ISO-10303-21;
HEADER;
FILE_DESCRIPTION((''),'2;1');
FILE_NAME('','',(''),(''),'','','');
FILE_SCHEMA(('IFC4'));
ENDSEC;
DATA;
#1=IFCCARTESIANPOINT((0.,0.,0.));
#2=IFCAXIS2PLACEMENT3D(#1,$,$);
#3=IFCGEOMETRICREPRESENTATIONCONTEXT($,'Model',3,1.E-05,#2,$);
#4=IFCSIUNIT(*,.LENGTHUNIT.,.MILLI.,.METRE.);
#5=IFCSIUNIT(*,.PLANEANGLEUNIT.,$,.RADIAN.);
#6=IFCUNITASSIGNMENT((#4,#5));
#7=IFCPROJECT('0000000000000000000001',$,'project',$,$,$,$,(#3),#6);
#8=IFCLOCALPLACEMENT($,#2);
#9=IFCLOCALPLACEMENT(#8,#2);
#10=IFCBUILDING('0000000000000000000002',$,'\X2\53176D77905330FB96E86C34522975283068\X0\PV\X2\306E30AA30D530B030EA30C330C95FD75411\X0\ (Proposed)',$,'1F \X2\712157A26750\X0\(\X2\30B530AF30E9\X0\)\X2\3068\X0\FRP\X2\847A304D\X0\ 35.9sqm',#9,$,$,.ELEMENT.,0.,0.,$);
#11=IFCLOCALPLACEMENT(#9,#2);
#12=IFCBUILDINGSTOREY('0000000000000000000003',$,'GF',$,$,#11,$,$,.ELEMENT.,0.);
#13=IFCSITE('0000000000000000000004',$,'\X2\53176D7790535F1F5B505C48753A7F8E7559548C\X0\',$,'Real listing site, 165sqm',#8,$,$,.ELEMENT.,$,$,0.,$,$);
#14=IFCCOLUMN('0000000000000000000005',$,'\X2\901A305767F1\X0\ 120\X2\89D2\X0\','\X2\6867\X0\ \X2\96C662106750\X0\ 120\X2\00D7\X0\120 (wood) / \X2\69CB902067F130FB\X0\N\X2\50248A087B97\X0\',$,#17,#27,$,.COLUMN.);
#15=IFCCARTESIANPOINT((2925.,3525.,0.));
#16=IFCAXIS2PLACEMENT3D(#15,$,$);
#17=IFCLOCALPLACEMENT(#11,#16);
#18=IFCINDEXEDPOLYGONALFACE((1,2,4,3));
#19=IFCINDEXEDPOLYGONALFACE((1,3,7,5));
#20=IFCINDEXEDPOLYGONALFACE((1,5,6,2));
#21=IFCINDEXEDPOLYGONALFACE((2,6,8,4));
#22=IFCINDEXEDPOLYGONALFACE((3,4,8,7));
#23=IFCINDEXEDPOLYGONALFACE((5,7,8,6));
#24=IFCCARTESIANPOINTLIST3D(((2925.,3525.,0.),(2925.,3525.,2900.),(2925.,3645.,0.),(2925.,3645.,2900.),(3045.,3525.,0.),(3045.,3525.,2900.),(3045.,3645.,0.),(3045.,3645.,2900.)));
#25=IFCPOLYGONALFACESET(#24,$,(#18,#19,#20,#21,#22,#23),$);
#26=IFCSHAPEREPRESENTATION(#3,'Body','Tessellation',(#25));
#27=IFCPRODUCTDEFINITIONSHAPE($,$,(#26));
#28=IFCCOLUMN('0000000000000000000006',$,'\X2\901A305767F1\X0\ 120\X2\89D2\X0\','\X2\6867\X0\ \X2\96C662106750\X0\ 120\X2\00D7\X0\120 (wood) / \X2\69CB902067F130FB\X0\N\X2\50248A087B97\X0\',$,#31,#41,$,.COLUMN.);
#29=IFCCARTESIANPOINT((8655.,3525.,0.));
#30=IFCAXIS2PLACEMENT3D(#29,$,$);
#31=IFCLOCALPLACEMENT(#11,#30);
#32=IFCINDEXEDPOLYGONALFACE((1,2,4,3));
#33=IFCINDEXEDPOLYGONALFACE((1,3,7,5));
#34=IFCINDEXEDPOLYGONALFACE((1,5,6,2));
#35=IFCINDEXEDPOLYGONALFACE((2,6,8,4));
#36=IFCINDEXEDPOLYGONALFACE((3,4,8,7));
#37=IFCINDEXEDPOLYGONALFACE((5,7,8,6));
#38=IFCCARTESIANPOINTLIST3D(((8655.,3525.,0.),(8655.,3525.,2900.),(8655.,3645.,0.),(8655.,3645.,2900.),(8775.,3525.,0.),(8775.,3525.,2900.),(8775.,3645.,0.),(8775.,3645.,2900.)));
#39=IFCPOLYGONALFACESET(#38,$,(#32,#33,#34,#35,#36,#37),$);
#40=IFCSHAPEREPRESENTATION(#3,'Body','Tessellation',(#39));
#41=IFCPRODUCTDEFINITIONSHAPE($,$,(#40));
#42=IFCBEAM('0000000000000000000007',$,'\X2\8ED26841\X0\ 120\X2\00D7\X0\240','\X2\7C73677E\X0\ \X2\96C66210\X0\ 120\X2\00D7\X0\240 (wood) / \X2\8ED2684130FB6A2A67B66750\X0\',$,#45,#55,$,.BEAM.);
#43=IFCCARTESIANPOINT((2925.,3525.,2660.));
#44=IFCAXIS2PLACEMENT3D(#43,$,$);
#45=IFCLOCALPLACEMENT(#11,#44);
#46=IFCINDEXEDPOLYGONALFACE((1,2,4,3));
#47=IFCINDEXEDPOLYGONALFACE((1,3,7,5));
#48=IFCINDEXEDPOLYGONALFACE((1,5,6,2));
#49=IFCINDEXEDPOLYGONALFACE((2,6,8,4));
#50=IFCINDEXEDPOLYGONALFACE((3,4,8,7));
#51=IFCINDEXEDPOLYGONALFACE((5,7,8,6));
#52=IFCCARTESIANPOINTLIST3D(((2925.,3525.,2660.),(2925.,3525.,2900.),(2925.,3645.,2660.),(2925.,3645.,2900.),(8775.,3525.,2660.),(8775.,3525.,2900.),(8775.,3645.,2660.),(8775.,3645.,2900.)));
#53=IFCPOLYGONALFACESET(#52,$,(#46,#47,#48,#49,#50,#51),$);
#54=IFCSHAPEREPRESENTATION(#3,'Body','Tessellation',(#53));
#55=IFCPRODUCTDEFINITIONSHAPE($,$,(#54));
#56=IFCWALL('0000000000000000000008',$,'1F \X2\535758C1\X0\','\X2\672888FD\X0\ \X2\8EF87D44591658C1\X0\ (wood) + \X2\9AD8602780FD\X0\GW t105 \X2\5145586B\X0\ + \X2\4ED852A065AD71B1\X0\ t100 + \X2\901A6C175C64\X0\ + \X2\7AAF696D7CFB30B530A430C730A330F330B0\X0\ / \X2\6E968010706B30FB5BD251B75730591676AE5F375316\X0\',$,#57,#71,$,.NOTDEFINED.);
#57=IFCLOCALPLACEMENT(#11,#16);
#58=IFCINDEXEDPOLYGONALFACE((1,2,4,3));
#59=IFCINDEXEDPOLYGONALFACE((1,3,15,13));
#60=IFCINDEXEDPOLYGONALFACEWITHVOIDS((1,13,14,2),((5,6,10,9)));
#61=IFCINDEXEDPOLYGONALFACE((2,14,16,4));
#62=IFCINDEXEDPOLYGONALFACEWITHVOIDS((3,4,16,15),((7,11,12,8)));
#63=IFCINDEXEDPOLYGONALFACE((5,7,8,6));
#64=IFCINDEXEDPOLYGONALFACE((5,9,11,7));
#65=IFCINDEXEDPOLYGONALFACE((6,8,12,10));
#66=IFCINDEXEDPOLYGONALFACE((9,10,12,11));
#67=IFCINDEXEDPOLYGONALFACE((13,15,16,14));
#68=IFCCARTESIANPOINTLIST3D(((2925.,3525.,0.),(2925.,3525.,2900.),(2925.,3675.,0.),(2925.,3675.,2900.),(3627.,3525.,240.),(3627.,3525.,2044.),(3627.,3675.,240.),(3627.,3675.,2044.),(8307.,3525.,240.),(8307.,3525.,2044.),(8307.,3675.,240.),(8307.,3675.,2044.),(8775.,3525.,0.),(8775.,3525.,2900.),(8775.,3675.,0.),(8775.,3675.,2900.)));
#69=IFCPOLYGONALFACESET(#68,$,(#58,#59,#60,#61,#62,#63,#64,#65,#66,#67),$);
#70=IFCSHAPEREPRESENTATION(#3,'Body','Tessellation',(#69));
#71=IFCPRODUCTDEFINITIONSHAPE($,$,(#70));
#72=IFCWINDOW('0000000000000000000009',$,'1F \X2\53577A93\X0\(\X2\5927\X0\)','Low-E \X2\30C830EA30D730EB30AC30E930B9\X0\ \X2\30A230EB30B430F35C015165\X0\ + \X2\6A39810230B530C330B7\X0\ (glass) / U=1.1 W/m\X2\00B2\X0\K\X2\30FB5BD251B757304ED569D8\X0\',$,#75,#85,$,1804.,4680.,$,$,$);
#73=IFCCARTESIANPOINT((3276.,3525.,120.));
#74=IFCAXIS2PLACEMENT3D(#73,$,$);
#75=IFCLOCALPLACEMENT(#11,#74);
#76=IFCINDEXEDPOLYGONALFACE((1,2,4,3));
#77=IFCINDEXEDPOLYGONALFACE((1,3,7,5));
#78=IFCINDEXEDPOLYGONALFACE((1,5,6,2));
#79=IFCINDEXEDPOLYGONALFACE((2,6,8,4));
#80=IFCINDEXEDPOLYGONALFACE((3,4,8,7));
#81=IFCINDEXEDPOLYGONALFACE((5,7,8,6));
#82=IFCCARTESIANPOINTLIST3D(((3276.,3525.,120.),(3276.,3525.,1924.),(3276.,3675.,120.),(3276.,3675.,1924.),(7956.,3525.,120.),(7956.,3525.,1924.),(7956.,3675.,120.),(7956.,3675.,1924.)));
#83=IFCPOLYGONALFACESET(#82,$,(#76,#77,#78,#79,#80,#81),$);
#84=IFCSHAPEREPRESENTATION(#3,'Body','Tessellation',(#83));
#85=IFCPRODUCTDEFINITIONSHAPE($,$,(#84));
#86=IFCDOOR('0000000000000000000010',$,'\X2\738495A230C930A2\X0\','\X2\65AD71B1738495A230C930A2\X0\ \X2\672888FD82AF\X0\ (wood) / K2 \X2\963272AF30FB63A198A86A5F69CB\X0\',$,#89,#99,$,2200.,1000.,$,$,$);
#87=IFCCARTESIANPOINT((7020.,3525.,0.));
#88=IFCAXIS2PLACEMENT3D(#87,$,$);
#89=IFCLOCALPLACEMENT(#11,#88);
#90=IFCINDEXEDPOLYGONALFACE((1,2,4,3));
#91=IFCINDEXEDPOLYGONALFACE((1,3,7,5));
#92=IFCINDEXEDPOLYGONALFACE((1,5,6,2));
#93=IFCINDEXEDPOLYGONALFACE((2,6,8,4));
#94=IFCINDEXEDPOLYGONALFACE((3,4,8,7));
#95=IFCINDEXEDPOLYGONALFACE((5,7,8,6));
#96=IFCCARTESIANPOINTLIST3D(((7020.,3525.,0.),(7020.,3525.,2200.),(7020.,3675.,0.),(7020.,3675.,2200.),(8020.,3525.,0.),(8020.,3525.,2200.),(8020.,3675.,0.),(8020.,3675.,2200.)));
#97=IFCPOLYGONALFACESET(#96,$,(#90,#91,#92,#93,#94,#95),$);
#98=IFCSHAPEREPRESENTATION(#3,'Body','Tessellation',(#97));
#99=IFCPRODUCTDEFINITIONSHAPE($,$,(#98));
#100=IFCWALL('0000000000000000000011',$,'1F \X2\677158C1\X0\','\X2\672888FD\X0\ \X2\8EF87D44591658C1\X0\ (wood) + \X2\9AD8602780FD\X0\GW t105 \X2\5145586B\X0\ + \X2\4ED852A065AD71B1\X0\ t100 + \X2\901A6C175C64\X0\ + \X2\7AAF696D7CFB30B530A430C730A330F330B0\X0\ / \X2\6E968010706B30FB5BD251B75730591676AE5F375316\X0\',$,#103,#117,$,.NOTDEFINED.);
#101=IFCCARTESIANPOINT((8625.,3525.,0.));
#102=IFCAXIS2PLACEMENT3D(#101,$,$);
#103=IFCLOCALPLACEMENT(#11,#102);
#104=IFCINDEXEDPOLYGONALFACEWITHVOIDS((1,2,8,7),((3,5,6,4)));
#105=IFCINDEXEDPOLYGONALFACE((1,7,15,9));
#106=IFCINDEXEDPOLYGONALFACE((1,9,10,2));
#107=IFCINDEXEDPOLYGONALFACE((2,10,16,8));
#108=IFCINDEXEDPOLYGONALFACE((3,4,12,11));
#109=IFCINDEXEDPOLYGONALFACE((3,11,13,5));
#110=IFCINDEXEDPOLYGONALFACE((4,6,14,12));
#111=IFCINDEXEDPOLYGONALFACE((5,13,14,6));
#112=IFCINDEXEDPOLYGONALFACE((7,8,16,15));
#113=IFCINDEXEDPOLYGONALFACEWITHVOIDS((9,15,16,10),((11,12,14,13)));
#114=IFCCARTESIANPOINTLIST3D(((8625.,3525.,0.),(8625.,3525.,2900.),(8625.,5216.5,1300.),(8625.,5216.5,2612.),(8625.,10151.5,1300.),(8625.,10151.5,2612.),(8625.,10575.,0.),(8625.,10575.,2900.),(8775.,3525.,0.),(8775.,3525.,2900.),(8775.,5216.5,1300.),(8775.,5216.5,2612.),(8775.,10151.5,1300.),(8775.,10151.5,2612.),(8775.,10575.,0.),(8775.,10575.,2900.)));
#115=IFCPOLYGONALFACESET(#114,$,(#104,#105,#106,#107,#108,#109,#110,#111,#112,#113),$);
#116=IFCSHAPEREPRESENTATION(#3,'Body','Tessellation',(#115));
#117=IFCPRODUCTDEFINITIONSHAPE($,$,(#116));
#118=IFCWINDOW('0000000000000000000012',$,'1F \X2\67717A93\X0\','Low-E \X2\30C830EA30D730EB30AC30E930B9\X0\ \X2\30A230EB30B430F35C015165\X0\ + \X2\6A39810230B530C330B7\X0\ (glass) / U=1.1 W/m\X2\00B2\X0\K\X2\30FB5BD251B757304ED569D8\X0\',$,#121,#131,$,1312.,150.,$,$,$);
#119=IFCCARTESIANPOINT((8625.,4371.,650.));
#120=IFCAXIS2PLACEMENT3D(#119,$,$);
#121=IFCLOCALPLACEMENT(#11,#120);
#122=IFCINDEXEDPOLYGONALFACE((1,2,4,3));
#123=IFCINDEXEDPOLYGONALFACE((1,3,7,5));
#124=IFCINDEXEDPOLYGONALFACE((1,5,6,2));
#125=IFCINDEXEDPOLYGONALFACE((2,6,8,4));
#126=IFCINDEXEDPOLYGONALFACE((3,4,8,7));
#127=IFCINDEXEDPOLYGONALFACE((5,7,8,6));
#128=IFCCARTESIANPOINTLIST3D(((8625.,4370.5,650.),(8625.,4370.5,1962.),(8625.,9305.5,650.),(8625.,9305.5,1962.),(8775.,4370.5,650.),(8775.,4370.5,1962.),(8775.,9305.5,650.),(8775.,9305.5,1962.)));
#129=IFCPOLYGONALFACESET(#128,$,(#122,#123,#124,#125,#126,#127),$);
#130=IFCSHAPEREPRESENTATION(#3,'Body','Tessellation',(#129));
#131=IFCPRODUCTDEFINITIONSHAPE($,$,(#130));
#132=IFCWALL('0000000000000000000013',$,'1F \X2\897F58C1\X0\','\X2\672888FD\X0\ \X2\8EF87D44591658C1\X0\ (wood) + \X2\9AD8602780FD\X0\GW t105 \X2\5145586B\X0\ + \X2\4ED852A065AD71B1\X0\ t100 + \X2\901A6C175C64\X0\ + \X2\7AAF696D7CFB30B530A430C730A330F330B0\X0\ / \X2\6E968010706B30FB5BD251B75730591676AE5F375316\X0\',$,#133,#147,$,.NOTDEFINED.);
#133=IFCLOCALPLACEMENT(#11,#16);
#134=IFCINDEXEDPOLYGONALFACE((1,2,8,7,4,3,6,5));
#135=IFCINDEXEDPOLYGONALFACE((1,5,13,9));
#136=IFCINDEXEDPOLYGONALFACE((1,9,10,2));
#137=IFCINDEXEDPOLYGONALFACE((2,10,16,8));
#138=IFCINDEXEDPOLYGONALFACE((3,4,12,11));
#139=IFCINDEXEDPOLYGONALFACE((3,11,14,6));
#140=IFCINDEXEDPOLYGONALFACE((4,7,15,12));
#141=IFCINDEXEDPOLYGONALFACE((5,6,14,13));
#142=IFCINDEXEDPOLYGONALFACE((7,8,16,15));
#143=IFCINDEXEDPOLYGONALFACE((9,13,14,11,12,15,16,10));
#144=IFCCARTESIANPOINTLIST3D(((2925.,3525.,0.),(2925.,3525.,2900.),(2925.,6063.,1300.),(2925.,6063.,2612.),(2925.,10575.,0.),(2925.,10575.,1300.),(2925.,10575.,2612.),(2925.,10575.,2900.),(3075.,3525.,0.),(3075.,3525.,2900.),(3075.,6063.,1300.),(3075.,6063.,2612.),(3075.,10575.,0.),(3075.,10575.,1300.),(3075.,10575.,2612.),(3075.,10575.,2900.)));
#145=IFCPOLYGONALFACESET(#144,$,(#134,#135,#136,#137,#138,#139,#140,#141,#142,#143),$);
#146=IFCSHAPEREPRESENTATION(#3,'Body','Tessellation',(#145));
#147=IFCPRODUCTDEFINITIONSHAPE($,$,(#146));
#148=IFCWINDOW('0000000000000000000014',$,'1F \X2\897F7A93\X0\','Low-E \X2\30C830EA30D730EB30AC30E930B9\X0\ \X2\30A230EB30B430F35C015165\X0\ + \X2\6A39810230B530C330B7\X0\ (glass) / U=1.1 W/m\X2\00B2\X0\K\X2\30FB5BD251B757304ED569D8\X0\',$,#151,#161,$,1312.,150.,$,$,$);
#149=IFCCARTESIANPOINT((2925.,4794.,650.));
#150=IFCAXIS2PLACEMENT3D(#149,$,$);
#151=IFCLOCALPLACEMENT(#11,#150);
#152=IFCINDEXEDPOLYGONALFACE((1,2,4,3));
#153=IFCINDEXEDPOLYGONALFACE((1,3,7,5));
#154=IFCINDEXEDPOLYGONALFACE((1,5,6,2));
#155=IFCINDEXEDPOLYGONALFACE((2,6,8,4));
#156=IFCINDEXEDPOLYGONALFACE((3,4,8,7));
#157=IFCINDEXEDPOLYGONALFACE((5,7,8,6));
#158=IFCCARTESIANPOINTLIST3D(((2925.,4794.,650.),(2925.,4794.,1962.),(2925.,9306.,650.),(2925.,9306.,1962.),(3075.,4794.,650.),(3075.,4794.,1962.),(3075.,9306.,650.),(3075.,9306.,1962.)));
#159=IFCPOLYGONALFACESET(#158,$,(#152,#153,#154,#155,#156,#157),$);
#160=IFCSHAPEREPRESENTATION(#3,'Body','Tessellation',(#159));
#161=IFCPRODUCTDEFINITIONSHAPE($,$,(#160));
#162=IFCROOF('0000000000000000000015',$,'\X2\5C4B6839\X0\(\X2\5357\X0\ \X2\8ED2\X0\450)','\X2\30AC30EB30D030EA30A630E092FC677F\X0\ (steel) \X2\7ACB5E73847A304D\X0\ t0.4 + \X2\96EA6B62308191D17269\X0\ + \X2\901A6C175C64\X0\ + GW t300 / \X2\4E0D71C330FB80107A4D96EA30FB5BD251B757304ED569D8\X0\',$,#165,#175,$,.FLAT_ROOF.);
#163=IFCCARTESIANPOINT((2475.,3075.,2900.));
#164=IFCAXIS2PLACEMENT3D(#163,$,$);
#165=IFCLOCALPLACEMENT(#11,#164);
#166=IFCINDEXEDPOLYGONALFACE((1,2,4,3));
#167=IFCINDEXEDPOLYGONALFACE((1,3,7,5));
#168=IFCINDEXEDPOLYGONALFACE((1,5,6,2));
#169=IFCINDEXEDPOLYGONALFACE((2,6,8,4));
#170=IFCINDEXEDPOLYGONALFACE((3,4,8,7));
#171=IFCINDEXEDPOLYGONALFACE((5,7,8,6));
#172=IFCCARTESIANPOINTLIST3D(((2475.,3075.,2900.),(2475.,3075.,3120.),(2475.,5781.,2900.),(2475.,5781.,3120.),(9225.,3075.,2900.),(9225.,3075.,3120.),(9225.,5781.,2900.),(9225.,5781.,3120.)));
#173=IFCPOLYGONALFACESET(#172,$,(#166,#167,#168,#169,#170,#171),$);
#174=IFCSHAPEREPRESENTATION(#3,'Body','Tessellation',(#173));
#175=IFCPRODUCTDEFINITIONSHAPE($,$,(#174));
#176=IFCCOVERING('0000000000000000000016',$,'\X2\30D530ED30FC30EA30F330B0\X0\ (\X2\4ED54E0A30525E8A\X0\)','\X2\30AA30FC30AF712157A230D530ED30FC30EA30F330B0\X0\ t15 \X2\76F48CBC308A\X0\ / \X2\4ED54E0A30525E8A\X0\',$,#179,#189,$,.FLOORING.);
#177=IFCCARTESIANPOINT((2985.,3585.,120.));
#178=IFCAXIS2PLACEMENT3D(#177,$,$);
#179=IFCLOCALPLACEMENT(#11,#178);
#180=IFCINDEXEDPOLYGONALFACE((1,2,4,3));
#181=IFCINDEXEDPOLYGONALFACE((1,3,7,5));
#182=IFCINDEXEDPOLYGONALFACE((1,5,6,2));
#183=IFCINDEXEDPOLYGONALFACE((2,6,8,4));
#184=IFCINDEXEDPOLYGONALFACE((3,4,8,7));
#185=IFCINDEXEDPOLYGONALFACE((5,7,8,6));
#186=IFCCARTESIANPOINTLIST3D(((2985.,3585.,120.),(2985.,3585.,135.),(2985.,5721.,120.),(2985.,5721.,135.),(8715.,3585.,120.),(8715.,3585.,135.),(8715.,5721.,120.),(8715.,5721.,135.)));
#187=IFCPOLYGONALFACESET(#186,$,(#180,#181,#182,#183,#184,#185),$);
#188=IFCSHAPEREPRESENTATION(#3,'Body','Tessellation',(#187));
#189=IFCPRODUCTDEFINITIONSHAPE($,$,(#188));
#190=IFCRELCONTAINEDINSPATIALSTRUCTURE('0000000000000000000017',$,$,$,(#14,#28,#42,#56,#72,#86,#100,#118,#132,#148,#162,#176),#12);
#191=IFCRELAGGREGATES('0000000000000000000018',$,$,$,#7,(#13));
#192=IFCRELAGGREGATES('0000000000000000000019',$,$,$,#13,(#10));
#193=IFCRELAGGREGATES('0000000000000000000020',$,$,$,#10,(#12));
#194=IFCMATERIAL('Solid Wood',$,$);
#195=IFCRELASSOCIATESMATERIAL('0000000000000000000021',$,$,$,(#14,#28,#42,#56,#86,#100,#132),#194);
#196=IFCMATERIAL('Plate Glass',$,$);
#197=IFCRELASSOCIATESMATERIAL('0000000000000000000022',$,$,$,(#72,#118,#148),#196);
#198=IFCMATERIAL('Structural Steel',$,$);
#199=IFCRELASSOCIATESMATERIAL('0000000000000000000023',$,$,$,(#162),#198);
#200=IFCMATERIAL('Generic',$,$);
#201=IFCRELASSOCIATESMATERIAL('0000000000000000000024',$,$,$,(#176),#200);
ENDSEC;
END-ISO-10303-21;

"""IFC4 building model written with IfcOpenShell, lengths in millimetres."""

from ifc_helpers import new_model, si_unit, frame, frame_2d, origin, place, context, project, spatial, rectangle, extrude, material, element, fill, save


model = new_model("IFC4")

# Units and contexts
model_context = context("Model", 3, precision=1e-05, world=origin())
ifc_project = project(units=[si_unit("LENGTHUNIT", "METRE", prefix="MILLI"), si_unit("PLANEANGLEUNIT", "RADIAN")], contexts=[model_context])

# Site, building, storey
site_placement = place(None, origin())
site = spatial("IfcSite", under=ifc_project, at=site_placement, Name="北海道弟子屈町美留和", ObjectType="Real listing site, 165sqm", CompositionType="ELEMENT", RefElevation=0.0)
building_placement = place(site_placement, origin())
building = spatial("IfcBuilding", under=site, at=building_placement, Name="北海道・雨水利用とPVのオフグリッド志向 (Proposed)", ObjectType="1F 無垢材(サクラ)とFRP葺き 35.9sqm", CompositionType="ELEMENT", ElevationOfRefHeight=0.0, ElevationOfTerrain=0.0)
storey_placement = place(building_placement, origin())
storey = spatial("IfcBuildingStorey", under=building, at=storey_placement, Name="GF", CompositionType="ELEMENT", Elevation=0.0)

# Columns
ifc_material_1 = material(Name="Solid Wood")
column_1_placement = place(storey_placement, frame((2925.0, 3525.0, 0.0)))
element("IfcColumn", 1, at=column_1_placement, inside=storey, material=ifc_material_1, Name="通し柱 120角", Description="桧 集成材 120×120 (wood) / 構造柱・N値計算", PredefinedType="COLUMN", context=model_context, shape_type="SweptSolid", body=[
    extrude(rectangle(XDim=120.0, YDim=120.0, at=frame_2d((60.0, 60.0))), frame((2925.0, 3525.0, 0.0)), (0.0, 0.0, 1.0), 2900.0),
])
column_2_placement = place(storey_placement, frame((8655.0, 3525.0, 0.0)))
element("IfcColumn", 2, at=column_2_placement, inside=storey, material=ifc_material_1, Name="通し柱 120角", Description="桧 集成材 120×120 (wood) / 構造柱・N値計算", PredefinedType="COLUMN", context=model_context, shape_type="SweptSolid", body=[
    extrude(rectangle(XDim=120.0, YDim=120.0, at=frame_2d((60.0, 60.0))), frame((8655.0, 3525.0, 0.0)), (0.0, 0.0, 1.0), 2900.0),
])

# Beam
beam_1_placement = place(storey_placement, frame((2925.0, 3525.0, 2660.0)))
element("IfcBeam", 3, at=beam_1_placement, inside=storey, material=ifc_material_1, Name="軒桁 120×240", Description="米松 集成 120×240 (wood) / 軒桁・横架材", PredefinedType="BEAM", context=model_context, shape_type="SweptSolid", body=[
    extrude(rectangle(XDim=5850.0, YDim=120.0, at=frame_2d((2925.0, 60.0))), frame((2925.0, 3525.0, 2660.0)), (0.0, 0.0, 1.0), 240.0),
])

# Wall, openings, window, door
wall_1_placement = place(storey_placement, frame((2925.0, 3525.0, 0.0)))
wall_1 = element("IfcWall", 4, at=wall_1_placement, inside=storey, material=ifc_material_1, Name="1F 南壁", Description="木製 軸組外壁 (wood) + 高性能GW t105 充填 + 付加断熱 t100 + 通気層 + 窯業系サイディング / 準耐火・寒冷地外皮強化", PredefinedType="NOTDEFINED", context=model_context, shape_type="SweptSolid", body=[
    extrude(rectangle(XDim=5850.0, YDim=150.0, at=frame_2d((2925.0, 75.0))), frame((2925.0, 3525.0, 0.0)), (0.0, 0.0, 1.0), 2900.0),
])
opening_1_placement = place(storey_placement, frame((3276.0, 3525.0, 120.0)))
opening_1 = element("IfcOpeningElement", 5, at=opening_1_placement, cuts=wall_1, PredefinedType="NOTDEFINED", context=model_context, shape_type="SweptSolid", body=[
    extrude(rectangle(XDim=4680.0, YDim=150.0, at=frame_2d((2340.0, 75.0))), frame((3276.0, 3525.0, 120.0)), (0.0, 0.0, 1.0), 1804.0),
])
opening_2_placement = place(storey_placement, frame((7020.0, 3525.0, 0.0)))
opening_2 = element("IfcOpeningElement", 6, at=opening_2_placement, cuts=wall_1, PredefinedType="NOTDEFINED", context=model_context, shape_type="SweptSolid", body=[
    extrude(rectangle(XDim=1000.0, YDim=150.0, at=frame_2d((500.0, 75.0))), frame((7020.0, 3525.0, 0.0)), (0.0, 0.0, 1.0), 2200.0),
])
ifc_material_2 = material(Name="Plate Glass")
window_1_placement = place(storey_placement, frame((3276.0, 3525.0, 120.0)))
window_1 = element("IfcWindow", 7, at=window_1_placement, inside=storey, material=ifc_material_2, Name="1F 南窓(大)", Description="Low-E トリプルガラス アルゴン封入 + 樹脂サッシ (glass) / U=1.1 W/m²K・寒冷地仕様", OverallHeight=1804.0, OverallWidth=4680.0, context=model_context, shape_type="SweptSolid", body=[
    extrude(rectangle(XDim=4680.0, YDim=150.0, at=frame_2d((2340.0, 75.0))), frame((3276.0, 3525.0, 120.0)), (0.0, 0.0, 1.0), 1804.0),
])
fill(opening_1, window_1)
door_placement = place(storey_placement, frame((7020.0, 3525.0, 0.0)))
door = element("IfcDoor", 8, at=door_placement, inside=storey, material=ifc_material_1, Name="玄関ドア", Description="断熱玄関ドア 木製芯 (wood) / K2 防犯・採風機構", OverallHeight=2200.0, OverallWidth=1000.0, context=model_context, shape_type="SweptSolid", body=[
    extrude(rectangle(XDim=1000.0, YDim=150.0, at=frame_2d((500.0, 75.0))), frame((7020.0, 3525.0, 0.0)), (0.0, 0.0, 1.0), 2200.0),
])
fill(opening_2, door)

# Walls, openings, windows
wall_2_placement = place(storey_placement, frame((8625.0, 3525.0, 0.0)))
wall_2 = element("IfcWall", 9, at=wall_2_placement, inside=storey, material=ifc_material_1, Name="1F 東壁", Description="木製 軸組外壁 (wood) + 高性能GW t105 充填 + 付加断熱 t100 + 通気層 + 窯業系サイディング / 準耐火・寒冷地外皮強化", PredefinedType="NOTDEFINED", context=model_context, shape_type="SweptSolid", body=[
    extrude(rectangle(XDim=150.0, YDim=7050.0, at=frame_2d((75.0, 3525.0))), frame((8625.0, 3525.0, 0.0)), (0.0, 0.0, 1.0), 2900.0),
])
opening_3_placement = place(storey_placement, frame((8625.0, 4371.0, 650.0)))
opening_3 = element("IfcOpeningElement", 10, at=opening_3_placement, cuts=wall_2, PredefinedType="NOTDEFINED", context=model_context, shape_type="SweptSolid", body=[
    extrude(rectangle(XDim=150.0, YDim=4935.0, at=frame_2d((75.0, 2467.0))), frame((8625.0, 4371.0, 650.0)), (0.0, 0.0, 1.0), 1312.0),
])
window_2_placement = place(storey_placement, frame((8625.0, 4371.0, 650.0)))
window_2 = element("IfcWindow", 11, at=window_2_placement, inside=storey, material=ifc_material_2, Name="1F 東窓", Description="Low-E トリプルガラス アルゴン封入 + 樹脂サッシ (glass) / U=1.1 W/m²K・寒冷地仕様", OverallHeight=1312.0, OverallWidth=150.0, context=model_context, shape_type="SweptSolid", body=[
    extrude(rectangle(XDim=150.0, YDim=4935.0, at=frame_2d((75.0, 2467.0))), frame((8625.0, 4371.0, 650.0)), (0.0, 0.0, 1.0), 1312.0),
])
fill(opening_3, window_2)
wall_3_placement = place(storey_placement, frame((2925.0, 3525.0, 0.0)))
wall_3 = element("IfcWall", 12, at=wall_3_placement, inside=storey, material=ifc_material_1, Name="1F 西壁", Description="木製 軸組外壁 (wood) + 高性能GW t105 充填 + 付加断熱 t100 + 通気層 + 窯業系サイディング / 準耐火・寒冷地外皮強化", PredefinedType="NOTDEFINED", context=model_context, shape_type="SweptSolid", body=[
    extrude(rectangle(XDim=150.0, YDim=7050.0, at=frame_2d((75.0, 3525.0))), frame((2925.0, 3525.0, 0.0)), (0.0, 0.0, 1.0), 2900.0),
])
opening_4_placement = place(storey_placement, frame((2925.0, 4794.0, 650.0)))
opening_4 = element("IfcOpeningElement", 13, at=opening_4_placement, cuts=wall_3, PredefinedType="NOTDEFINED", context=model_context, shape_type="SweptSolid", body=[
    extrude(rectangle(XDim=150.0, YDim=4512.0, at=frame_2d((75.0, 2256.0))), frame((2925.0, 4794.0, 650.0)), (0.0, 0.0, 1.0), 1312.0),
])
window_3_placement = place(storey_placement, frame((2925.0, 4794.0, 650.0)))
window_3 = element("IfcWindow", 14, at=window_3_placement, inside=storey, material=ifc_material_2, Name="1F 西窓", Description="Low-E トリプルガラス アルゴン封入 + 樹脂サッシ (glass) / U=1.1 W/m²K・寒冷地仕様", OverallHeight=1312.0, OverallWidth=150.0, context=model_context, shape_type="SweptSolid", body=[
    extrude(rectangle(XDim=150.0, YDim=4512.0, at=frame_2d((75.0, 2256.0))), frame((2925.0, 4794.0, 650.0)), (0.0, 0.0, 1.0), 1312.0),
])
fill(opening_4, window_3)

# Roof
ifc_material_3 = material(Name="Structural Steel")
roof_placement = place(storey_placement, frame((2475.0, 3075.0, 2900.0)))
element("IfcRoof", 15, at=roof_placement, inside=storey, material=ifc_material_3, Name="屋根(南 軒450)", Description="ガルバリウム鋼板 (steel) 立平葺き t0.4 + 雪止め金物 + 通気層 + GW t300 / 不燃・耐積雪・寒冷地仕様", PredefinedType="FLAT_ROOF", context=model_context, shape_type="SweptSolid", body=[
    extrude(rectangle(XDim=6750.0, YDim=2706.0, at=frame_2d((3375.0, 1353.0))), frame((2475.0, 3075.0, 2900.0)), (0.0, 0.0, 1.0), 220.0),
])

# Covering
ifc_material_4 = material(Name="Generic")
covering_1_placement = place(storey_placement, frame((2985.0, 3585.0, 120.0)))
element("IfcCovering", 16, at=covering_1_placement, inside=storey, material=ifc_material_4, Name="フローリング (仕上げ床)", Description="オーク無垢フローリング t15 直貼り / 仕上げ床", PredefinedType="FLOORING", context=model_context, shape_type="SweptSolid", body=[
    extrude(rectangle(XDim=5730.0, YDim=2136.0, at=frame_2d((2865.0, 1068.0))), frame((2985.0, 3585.0, 120.0)), (0.0, 0.0, 1.0), 15.0),
])

save(model, "model.ifc")
